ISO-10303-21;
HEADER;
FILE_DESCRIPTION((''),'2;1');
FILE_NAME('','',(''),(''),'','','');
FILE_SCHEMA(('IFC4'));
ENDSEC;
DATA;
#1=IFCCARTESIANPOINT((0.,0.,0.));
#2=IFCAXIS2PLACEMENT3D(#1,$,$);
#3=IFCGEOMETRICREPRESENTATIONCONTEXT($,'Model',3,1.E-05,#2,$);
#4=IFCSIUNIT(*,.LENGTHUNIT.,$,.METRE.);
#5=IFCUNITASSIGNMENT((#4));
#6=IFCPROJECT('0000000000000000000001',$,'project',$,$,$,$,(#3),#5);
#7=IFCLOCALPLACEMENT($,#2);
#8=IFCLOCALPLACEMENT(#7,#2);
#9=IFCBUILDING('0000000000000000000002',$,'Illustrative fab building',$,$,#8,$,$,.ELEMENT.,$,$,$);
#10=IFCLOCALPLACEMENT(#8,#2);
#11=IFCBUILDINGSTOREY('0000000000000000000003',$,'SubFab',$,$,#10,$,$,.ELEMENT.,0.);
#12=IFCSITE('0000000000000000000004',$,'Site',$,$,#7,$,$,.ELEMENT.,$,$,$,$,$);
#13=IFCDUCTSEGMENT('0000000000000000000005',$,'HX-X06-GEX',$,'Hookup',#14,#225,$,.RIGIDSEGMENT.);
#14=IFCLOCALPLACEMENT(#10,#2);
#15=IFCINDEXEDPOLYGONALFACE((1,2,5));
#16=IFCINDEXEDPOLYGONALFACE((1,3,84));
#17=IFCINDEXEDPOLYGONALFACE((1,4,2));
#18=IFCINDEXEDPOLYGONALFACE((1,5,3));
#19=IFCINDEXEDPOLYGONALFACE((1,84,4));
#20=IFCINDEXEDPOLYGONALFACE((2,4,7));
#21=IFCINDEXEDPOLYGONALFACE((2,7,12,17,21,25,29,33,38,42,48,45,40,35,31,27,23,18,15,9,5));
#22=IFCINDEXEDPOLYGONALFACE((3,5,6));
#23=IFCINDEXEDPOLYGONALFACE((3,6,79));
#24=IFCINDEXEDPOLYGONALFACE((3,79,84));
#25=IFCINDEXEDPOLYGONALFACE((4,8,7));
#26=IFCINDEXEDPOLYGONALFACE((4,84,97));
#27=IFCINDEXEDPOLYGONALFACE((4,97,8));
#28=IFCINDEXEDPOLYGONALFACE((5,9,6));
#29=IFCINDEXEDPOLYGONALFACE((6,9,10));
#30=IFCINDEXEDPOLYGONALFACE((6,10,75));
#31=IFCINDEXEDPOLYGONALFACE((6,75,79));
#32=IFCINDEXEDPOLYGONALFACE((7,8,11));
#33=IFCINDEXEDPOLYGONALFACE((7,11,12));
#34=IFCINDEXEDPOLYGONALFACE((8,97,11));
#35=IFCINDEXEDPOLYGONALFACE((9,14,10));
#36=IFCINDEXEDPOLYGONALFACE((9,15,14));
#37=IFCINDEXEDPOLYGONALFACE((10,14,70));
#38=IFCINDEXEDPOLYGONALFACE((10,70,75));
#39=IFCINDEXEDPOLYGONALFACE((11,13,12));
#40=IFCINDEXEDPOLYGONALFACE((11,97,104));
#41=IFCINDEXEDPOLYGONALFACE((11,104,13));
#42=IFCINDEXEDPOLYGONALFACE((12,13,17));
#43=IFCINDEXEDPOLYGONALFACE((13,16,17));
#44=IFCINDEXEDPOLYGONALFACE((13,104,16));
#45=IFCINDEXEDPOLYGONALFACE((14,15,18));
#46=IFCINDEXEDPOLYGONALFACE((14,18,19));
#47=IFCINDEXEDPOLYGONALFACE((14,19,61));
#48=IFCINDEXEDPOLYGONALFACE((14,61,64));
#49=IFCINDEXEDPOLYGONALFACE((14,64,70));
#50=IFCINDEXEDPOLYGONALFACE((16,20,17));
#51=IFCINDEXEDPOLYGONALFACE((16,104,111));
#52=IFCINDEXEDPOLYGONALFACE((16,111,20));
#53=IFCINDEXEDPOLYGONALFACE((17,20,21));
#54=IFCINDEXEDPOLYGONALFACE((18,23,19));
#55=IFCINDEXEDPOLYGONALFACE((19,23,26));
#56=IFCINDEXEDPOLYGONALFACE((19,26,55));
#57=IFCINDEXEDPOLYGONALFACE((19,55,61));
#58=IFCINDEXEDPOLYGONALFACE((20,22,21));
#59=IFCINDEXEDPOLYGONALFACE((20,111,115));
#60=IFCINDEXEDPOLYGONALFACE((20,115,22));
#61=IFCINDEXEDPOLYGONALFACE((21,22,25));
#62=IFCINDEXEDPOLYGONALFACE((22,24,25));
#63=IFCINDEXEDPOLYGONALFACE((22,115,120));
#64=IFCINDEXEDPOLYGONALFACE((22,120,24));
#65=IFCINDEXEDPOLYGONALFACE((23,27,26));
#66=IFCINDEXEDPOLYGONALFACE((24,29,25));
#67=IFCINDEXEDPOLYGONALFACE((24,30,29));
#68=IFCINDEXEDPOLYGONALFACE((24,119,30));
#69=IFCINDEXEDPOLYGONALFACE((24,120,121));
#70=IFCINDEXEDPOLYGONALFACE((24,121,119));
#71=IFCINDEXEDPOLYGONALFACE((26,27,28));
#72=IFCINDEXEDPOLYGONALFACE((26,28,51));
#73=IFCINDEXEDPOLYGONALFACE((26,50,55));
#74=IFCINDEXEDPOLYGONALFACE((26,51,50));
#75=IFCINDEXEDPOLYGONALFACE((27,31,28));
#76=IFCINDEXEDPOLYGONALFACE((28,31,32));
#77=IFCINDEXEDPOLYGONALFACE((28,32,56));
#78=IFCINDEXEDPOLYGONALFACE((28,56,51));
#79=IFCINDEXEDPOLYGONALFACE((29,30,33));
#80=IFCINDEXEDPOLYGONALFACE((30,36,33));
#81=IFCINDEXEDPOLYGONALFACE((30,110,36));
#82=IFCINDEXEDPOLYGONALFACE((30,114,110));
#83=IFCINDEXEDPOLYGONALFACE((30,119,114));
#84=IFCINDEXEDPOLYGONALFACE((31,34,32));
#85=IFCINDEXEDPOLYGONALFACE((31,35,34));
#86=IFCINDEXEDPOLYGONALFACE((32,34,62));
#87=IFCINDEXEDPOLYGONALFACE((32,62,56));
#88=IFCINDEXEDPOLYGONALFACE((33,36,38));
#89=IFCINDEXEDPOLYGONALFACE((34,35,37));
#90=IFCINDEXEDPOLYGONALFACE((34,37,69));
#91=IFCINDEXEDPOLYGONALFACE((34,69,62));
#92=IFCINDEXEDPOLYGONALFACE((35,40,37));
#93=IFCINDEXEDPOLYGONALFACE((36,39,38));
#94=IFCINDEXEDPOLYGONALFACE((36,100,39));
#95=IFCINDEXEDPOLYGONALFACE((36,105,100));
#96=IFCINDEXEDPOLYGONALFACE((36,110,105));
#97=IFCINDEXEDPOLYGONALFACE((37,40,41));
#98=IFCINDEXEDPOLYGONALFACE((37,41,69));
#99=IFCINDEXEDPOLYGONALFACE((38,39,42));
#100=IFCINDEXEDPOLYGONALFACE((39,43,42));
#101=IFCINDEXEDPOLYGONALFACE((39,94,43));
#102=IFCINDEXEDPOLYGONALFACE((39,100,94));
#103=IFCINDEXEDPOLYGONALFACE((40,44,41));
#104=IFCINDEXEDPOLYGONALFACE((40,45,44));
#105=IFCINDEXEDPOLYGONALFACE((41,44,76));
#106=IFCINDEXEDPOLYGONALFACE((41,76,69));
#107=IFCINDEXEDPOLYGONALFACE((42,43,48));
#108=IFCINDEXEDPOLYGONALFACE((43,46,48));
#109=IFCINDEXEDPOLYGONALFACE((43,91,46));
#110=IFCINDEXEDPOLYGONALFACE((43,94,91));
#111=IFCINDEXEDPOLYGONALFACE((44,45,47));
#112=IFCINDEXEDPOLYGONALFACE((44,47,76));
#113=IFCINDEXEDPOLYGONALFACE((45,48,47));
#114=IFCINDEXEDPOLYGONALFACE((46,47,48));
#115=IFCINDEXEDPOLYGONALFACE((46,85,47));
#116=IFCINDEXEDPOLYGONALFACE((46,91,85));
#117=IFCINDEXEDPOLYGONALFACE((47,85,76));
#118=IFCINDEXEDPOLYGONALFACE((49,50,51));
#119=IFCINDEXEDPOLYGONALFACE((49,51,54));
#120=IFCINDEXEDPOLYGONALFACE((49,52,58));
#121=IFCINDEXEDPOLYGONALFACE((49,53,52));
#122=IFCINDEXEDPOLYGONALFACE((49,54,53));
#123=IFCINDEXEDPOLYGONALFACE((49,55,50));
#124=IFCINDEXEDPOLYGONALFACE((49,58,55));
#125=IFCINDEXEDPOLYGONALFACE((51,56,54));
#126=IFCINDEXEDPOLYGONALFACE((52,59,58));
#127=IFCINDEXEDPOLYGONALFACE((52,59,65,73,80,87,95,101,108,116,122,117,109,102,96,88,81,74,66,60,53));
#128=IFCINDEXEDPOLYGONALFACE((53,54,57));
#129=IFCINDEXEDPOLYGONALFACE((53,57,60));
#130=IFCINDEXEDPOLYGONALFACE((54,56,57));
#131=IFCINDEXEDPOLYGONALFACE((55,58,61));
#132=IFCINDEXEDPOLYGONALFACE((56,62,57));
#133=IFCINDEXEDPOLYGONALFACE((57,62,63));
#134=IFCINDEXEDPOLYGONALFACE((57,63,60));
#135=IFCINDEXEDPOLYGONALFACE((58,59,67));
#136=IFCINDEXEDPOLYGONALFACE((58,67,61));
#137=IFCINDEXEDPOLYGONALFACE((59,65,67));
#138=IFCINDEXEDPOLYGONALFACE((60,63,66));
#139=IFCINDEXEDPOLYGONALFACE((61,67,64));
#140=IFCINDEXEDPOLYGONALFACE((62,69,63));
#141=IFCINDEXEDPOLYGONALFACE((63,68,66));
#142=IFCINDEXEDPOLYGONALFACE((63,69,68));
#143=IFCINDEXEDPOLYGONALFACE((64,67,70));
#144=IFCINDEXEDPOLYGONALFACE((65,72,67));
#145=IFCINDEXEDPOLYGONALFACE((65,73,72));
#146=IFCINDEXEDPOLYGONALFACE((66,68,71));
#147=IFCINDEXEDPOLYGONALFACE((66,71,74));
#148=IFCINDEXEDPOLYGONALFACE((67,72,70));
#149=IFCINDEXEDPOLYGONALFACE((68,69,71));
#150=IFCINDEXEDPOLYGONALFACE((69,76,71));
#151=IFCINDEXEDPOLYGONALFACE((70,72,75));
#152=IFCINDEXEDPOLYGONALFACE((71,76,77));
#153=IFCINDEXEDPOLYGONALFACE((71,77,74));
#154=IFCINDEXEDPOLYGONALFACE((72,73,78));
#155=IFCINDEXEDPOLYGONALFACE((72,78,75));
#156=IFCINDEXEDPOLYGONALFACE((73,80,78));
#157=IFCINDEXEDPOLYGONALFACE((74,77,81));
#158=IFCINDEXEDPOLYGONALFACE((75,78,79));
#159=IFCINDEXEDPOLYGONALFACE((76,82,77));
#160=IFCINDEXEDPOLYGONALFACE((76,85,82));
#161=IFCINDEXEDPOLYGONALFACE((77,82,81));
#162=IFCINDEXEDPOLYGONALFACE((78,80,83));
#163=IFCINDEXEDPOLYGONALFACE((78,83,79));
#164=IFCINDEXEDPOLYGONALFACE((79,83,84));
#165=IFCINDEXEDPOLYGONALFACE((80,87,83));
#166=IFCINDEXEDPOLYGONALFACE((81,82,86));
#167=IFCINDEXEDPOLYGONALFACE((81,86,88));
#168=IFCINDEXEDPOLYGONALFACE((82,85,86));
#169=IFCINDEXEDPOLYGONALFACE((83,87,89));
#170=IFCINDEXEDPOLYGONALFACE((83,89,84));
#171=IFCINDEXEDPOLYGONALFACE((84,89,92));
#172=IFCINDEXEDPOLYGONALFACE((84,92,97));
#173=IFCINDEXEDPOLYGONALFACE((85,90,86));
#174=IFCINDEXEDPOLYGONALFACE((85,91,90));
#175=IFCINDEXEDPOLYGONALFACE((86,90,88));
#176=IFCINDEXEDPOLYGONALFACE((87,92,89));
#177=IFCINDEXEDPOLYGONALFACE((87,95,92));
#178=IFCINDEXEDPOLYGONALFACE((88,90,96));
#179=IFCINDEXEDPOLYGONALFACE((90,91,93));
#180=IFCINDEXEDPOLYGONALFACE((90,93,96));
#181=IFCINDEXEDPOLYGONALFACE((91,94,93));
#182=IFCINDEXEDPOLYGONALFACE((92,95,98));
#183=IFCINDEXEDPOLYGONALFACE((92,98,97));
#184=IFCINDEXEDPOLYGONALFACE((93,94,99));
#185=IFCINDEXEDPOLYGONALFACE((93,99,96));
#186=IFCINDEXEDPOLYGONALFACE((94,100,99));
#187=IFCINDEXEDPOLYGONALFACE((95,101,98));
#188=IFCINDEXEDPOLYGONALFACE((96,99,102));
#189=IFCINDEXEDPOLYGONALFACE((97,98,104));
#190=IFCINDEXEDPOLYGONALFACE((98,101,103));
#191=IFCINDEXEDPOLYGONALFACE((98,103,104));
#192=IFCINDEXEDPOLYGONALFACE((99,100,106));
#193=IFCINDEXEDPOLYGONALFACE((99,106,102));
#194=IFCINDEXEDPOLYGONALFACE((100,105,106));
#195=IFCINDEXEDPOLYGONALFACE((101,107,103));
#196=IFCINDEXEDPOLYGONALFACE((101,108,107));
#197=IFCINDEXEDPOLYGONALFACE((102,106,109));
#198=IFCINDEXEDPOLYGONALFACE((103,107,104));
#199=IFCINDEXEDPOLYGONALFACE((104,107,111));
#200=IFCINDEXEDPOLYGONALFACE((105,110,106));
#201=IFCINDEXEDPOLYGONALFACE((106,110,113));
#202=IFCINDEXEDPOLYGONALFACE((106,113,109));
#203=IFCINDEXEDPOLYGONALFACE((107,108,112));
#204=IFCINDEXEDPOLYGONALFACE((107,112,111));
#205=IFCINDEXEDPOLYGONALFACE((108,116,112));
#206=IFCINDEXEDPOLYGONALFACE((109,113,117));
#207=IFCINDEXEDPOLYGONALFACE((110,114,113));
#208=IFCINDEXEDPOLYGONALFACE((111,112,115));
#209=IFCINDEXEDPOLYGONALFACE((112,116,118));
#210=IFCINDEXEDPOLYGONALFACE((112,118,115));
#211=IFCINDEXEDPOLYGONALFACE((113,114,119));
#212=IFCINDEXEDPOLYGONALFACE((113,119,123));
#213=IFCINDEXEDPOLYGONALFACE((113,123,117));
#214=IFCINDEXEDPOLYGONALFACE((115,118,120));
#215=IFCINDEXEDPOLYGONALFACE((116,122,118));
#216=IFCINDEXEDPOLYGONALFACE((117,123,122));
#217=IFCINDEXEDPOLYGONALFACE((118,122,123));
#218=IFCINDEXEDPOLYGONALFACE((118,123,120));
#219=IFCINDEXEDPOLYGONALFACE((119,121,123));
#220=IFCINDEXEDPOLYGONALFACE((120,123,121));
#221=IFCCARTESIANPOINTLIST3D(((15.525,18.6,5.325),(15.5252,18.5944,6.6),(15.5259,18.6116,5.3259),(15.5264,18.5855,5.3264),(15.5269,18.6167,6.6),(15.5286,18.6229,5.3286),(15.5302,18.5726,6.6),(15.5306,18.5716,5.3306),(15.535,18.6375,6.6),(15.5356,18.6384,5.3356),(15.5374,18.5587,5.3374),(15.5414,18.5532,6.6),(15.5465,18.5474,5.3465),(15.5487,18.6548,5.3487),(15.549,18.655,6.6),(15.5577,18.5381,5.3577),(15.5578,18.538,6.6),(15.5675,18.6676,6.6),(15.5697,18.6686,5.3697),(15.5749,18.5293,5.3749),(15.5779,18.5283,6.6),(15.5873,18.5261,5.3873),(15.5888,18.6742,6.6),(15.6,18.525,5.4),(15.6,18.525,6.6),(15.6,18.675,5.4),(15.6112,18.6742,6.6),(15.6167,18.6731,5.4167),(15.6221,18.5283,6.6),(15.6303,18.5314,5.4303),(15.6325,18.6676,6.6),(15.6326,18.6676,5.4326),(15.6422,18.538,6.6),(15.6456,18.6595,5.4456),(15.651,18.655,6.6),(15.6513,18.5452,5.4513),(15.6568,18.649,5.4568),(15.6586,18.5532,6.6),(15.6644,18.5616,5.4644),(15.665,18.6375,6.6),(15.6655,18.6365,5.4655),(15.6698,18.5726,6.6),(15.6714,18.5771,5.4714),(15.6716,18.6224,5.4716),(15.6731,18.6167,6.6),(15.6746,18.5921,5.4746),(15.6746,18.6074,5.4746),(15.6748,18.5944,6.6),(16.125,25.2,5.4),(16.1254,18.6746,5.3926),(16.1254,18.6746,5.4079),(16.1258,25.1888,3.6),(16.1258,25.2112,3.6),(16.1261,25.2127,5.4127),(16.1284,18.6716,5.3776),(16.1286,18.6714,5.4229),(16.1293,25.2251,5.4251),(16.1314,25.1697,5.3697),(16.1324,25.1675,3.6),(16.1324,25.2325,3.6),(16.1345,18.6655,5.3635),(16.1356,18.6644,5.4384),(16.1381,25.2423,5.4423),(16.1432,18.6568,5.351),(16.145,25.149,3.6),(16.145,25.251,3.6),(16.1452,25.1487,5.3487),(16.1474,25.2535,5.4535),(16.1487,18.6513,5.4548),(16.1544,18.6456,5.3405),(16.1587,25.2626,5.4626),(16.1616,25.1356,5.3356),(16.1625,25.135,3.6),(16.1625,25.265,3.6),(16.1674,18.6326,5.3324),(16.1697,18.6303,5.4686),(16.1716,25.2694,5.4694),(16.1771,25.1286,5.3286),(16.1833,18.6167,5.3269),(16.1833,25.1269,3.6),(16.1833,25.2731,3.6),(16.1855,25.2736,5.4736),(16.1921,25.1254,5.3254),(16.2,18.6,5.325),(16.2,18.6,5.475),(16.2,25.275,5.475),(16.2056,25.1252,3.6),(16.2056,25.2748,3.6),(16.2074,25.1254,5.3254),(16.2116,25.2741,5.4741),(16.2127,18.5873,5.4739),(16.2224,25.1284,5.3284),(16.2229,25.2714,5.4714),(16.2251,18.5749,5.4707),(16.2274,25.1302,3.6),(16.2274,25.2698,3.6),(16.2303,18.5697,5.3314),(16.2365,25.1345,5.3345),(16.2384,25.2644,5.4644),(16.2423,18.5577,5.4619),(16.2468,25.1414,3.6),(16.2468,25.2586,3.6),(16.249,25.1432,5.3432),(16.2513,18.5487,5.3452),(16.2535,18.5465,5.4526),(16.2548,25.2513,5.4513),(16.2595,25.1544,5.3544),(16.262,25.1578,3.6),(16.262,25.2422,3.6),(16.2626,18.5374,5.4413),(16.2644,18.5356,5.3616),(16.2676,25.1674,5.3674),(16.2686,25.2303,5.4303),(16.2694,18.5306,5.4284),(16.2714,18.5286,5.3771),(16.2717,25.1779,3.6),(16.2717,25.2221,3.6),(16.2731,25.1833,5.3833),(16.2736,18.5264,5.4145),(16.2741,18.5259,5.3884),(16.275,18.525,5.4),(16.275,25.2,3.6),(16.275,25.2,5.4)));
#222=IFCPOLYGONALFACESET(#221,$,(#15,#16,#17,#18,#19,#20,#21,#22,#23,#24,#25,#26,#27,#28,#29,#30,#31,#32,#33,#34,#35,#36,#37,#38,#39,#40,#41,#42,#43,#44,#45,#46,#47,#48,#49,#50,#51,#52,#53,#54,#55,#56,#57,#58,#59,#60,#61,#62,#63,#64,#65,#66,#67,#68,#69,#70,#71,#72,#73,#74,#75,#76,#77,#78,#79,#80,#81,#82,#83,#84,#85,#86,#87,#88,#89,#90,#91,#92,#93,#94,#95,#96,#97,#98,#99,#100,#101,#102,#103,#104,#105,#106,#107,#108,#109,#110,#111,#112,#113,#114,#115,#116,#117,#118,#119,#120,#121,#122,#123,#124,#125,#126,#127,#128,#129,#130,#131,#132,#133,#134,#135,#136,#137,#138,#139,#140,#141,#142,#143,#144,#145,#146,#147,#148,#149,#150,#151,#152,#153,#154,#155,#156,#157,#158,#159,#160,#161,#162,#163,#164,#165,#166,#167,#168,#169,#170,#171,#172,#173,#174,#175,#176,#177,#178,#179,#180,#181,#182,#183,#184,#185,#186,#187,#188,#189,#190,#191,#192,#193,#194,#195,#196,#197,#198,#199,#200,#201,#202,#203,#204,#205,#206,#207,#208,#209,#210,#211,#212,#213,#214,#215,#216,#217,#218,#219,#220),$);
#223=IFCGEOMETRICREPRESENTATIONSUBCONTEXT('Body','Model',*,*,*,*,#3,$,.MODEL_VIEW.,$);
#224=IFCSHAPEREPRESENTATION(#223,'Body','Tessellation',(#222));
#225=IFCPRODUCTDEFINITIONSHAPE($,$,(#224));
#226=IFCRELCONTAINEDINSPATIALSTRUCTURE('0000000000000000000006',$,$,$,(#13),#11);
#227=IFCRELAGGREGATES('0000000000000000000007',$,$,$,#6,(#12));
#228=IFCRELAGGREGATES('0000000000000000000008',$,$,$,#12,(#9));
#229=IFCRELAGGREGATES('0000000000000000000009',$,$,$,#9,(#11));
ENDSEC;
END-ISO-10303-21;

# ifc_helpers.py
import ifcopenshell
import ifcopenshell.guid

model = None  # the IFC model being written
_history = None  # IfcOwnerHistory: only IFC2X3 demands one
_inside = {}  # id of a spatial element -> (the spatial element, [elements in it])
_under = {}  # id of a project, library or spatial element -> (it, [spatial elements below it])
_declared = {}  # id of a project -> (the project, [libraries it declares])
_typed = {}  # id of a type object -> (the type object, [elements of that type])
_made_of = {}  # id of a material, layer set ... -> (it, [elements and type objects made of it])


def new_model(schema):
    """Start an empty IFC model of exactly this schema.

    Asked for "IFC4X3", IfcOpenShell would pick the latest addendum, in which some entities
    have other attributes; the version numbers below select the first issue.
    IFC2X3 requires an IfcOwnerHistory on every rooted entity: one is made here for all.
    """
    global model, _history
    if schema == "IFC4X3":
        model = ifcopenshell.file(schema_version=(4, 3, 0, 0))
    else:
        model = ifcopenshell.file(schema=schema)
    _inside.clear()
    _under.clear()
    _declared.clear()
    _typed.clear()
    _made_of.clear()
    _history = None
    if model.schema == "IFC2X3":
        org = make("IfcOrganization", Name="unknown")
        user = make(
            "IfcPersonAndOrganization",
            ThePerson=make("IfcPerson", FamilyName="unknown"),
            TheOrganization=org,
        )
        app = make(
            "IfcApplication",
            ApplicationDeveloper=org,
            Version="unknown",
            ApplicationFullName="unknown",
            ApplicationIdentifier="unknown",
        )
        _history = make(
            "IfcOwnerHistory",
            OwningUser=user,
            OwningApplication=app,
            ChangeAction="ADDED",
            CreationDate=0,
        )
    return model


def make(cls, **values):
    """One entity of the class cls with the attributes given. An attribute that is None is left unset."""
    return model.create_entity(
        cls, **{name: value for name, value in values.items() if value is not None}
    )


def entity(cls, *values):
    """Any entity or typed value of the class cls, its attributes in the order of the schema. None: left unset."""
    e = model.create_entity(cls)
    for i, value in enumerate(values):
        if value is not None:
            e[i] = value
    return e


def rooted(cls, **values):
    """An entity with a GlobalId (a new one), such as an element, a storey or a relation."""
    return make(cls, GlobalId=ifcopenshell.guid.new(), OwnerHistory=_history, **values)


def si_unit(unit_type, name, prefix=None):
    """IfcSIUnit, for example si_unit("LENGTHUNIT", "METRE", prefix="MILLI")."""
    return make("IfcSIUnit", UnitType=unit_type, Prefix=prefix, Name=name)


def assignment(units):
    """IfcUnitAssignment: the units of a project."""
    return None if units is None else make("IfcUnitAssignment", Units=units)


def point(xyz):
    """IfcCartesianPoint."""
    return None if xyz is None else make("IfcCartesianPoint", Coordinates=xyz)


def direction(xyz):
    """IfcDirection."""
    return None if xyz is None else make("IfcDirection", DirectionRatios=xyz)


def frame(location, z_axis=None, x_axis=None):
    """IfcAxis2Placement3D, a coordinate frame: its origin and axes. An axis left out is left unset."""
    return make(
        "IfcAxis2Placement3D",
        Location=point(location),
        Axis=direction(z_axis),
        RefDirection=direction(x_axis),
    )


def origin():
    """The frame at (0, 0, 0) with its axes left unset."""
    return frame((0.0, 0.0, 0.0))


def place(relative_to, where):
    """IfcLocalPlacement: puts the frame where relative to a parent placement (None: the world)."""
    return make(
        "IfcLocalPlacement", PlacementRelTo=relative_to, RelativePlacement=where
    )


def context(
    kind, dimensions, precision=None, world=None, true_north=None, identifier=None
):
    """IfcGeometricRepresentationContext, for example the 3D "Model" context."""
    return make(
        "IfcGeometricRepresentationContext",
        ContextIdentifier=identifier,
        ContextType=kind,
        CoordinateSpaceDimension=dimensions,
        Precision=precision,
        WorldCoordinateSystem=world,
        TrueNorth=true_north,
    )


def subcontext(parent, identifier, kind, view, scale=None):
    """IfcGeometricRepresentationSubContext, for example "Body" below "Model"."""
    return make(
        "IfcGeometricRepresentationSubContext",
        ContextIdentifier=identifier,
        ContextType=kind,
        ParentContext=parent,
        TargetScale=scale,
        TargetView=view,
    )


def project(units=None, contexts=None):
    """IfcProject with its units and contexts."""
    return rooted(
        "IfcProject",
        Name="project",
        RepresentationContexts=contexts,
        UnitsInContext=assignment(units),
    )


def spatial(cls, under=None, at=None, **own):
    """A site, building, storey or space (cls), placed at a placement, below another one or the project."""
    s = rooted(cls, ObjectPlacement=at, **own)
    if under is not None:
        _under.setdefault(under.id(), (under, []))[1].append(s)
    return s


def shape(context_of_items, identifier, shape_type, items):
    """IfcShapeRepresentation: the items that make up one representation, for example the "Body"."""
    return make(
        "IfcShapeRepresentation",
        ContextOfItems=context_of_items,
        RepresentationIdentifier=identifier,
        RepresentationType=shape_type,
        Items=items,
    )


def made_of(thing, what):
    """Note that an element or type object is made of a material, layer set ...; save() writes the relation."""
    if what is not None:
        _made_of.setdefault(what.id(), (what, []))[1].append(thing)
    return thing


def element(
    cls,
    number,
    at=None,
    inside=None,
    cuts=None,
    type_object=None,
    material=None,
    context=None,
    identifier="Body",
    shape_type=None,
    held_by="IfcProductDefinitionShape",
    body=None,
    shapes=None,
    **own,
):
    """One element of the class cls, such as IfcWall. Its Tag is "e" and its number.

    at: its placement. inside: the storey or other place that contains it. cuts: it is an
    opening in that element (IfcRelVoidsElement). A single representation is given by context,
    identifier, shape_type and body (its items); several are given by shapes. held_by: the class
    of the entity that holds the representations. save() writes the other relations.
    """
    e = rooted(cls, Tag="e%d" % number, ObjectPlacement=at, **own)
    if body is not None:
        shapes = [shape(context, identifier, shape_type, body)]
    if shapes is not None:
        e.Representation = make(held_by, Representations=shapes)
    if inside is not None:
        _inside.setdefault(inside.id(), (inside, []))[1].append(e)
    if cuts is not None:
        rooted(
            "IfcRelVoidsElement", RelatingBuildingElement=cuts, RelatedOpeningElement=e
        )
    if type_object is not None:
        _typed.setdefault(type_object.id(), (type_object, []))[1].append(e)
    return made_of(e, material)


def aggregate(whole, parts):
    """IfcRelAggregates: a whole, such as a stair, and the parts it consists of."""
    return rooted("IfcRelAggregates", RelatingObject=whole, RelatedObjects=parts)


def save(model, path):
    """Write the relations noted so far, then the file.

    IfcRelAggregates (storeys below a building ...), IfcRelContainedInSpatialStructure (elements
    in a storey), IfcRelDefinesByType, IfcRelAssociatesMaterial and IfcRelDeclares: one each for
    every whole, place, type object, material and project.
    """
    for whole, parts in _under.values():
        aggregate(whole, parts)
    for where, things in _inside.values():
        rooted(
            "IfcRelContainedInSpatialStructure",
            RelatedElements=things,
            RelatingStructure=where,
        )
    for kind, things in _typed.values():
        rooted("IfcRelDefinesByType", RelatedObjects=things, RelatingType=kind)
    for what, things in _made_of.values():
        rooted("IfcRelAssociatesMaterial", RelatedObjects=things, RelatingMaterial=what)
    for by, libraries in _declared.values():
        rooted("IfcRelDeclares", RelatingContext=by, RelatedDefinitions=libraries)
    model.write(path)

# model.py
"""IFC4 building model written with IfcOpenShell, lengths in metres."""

from ifc_helpers import new_model, entity, si_unit, origin, place, context, subcontext, project, spatial, element, save


model = new_model("IFC4")

# Units and contexts
model_context = context("Model", 3, precision=1e-05, world=origin())
body_context = subcontext(model_context, "Body", "Model", "MODEL_VIEW")
ifc_project = project(units=[si_unit("LENGTHUNIT", "METRE")], contexts=[model_context])

# Site, building, storey
site_placement = place(None, origin())
site = spatial("IfcSite", under=ifc_project, at=site_placement, Name="Site", CompositionType="ELEMENT")
building_placement = place(site_placement, origin())
building = spatial("IfcBuilding", under=site, at=building_placement, Name="Illustrative fab building", CompositionType="ELEMENT")
storey_placement = place(building_placement, origin())
storey = spatial("IfcBuildingStorey", under=building, at=storey_placement, Name="SubFab", CompositionType="ELEMENT", Elevation=0.0)

# Duct segment
duct_segment_1_placement = place(storey_placement, origin())
element("IfcDuctSegment", 1, at=duct_segment_1_placement, inside=storey, Name="HX-X06-GEX", ObjectType="Hookup", PredefinedType="RIGIDSEGMENT", context=body_context, shape_type="AdvancedSweptSolid", body=[
    entity("IfcSweptDiskSolid", entity("IfcPolyline", [entity("IfcCartesianPoint", [16.2, 25.2, 3.6]), entity("IfcCartesianPoint", [16.2, 25.2, 5.4]), entity("IfcCartesianPoint", [16.2, 18.6, 5.4]), entity("IfcCartesianPoint", [15.6, 18.6, 5.4]), entity("IfcCartesianPoint", [15.6, 18.6, 6.6])]), 0.075),
])

save(model, "model.ifc")
